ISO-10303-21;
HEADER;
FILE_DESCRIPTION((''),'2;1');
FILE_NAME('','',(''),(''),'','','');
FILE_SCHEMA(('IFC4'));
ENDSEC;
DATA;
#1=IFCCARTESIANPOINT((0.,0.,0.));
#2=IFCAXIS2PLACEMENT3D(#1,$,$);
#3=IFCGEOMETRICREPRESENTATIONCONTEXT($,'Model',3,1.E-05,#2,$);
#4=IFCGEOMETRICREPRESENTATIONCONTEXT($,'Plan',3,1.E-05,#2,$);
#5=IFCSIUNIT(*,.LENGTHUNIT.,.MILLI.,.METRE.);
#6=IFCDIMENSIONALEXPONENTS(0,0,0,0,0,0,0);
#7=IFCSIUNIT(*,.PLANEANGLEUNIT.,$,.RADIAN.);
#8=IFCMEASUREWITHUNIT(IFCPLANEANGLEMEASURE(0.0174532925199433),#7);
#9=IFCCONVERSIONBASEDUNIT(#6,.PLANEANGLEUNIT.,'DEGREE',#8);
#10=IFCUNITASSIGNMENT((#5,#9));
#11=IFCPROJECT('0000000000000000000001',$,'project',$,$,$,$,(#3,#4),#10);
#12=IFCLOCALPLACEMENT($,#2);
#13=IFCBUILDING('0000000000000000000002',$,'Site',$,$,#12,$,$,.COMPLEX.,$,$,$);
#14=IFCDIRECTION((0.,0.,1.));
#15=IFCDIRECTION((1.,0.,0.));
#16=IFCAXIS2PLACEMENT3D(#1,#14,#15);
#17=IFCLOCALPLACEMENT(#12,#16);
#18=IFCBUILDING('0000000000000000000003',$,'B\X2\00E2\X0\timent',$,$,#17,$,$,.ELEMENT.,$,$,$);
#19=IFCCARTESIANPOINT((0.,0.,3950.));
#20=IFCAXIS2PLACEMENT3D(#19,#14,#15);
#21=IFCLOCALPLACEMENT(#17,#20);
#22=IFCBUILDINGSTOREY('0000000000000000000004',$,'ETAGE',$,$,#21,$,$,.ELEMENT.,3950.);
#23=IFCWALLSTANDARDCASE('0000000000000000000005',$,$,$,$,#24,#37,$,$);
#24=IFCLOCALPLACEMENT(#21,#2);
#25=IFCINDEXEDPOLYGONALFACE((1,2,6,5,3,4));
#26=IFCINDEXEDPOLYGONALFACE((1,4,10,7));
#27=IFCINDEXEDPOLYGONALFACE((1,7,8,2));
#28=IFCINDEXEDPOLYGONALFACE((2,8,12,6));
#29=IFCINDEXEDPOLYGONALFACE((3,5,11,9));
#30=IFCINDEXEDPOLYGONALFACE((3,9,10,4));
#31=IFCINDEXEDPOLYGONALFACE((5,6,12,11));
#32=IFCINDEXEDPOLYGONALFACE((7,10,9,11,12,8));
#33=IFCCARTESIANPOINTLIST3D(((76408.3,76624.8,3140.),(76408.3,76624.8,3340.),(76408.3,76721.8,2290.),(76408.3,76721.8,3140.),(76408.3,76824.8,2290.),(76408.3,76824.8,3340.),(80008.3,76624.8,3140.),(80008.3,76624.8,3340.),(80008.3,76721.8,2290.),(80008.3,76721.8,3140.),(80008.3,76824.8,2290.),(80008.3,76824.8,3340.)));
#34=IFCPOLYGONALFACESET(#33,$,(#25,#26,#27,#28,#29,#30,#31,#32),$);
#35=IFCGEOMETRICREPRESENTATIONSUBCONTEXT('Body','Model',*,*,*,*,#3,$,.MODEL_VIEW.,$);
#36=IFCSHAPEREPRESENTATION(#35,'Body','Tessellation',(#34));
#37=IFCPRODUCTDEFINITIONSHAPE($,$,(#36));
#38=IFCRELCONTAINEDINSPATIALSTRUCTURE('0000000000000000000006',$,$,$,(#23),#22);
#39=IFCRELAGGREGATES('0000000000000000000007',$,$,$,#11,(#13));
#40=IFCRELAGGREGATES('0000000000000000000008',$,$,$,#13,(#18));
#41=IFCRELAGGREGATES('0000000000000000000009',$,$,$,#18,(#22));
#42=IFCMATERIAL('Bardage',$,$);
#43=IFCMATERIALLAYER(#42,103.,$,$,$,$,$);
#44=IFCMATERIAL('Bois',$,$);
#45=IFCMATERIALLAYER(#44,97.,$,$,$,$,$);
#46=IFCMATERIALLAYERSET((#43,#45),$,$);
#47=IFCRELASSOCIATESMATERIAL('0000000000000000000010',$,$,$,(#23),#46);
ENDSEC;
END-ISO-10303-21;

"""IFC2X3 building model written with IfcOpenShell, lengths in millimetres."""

from ifc_helpers import new_model, entity, si_unit, converted_unit, frame, frame_2d, origin, origin_with_axes, place, context, subcontext, project, spatial, polyline, rectangle, extrude, clip, bounded_halfspace, material, layer, layer_set, layer_usage, element, save


model = new_model("IFC2X3")

# Units and contexts
model_context = context("Model", 3, precision=1e-05, world=origin())
plan_context = context("Plan", 3, precision=1e-05, world=origin())
body_context = subcontext(model_context, "Body", "Model", "MODEL_VIEW")
ifc_project = project(units=[si_unit("LENGTHUNIT", "METRE", prefix="MILLI"), converted_unit("PLANEANGLEUNIT", "DEGREE", entity("IfcPlaneAngleMeasure", 0.0174532925199433), si_unit("PLANEANGLEUNIT", "RADIAN"), dimensions=[0, 0, 0, 0, 0, 0, 0])], contexts=[model_context, plan_context])

# Buildings, storey
building_1_placement = place(None, origin())
building_1 = spatial("IfcBuilding", under=ifc_project, at=building_1_placement, Name="Site", CompositionType="COMPLEX")
building_2_placement = place(building_1_placement, origin_with_axes())
building_2 = spatial("IfcBuilding", under=building_1, at=building_2_placement, Name="Bâtiment", CompositionType="ELEMENT")
storey_placement = place(building_2_placement, frame((0.0, 0.0, 3950.0), z_axis=(0.0, 0.0, 1.0), x_axis=(1.0, 0.0, 0.0)))
storey = spatial("IfcBuildingStorey", under=building_2, at=storey_placement, Name="ETAGE", CompositionType="ELEMENT", Elevation=3950.0)

# Wall
ifc_material_1 = material(Name="Bardage")
ifc_layer_1 = layer(ifc_material_1, 103.0)
ifc_material_2 = material(Name="Bois")
ifc_layer_2 = layer(ifc_material_2, 97.0)
ifc_layer_set_1 = layer_set([ifc_layer_1, ifc_layer_2])
ifc_layer_usage_1 = layer_usage(ifc_layer_set_1, "AXIS2", "POSITIVE", 0.0)
wall_1_placement = place(storey_placement, frame((80008.3, 76824.8, 2290.0), z_axis=(0.0, 0.0, 1.0), x_axis=(-1.0, 0.0, 0.0)))
element("IfcWallStandardCase", 1, at=wall_1_placement, inside=storey, material=ifc_layer_usage_1, context=body_context, shape_type="Clipping", body=[
    clip(clip(extrude(rectangle(XDim=3600.0, YDim=200.0, at=frame_2d((1800.0, 100.0), x_axis=(1.0, 0.0))), origin_with_axes(), (0.0, 0.0, 1.0), 1050.0), bounded_halfspace(frame((0.0, 103.0, 0.0), z_axis=(0.0, 0.0, 1.0), x_axis=(0.0, -1.0, 0.0)), True, origin(), polyline([(0.0, 103.0), (0.0, 0.0), (3600.0, 0.0), (3600.0, 103.0), (0.0, 103.0)]))), bounded_halfspace(frame((0.0, 200.0, 850.0), z_axis=(0.0, 0.0, 1.0), x_axis=(0.0, -1.0, 0.0)), True, origin(), polyline([(0.0, 200.0), (0.0, 103.0), (3600.0, 103.0), (3600.0, 200.0), (0.0, 200.0)]))),
])

save(model, "model.ifc")
